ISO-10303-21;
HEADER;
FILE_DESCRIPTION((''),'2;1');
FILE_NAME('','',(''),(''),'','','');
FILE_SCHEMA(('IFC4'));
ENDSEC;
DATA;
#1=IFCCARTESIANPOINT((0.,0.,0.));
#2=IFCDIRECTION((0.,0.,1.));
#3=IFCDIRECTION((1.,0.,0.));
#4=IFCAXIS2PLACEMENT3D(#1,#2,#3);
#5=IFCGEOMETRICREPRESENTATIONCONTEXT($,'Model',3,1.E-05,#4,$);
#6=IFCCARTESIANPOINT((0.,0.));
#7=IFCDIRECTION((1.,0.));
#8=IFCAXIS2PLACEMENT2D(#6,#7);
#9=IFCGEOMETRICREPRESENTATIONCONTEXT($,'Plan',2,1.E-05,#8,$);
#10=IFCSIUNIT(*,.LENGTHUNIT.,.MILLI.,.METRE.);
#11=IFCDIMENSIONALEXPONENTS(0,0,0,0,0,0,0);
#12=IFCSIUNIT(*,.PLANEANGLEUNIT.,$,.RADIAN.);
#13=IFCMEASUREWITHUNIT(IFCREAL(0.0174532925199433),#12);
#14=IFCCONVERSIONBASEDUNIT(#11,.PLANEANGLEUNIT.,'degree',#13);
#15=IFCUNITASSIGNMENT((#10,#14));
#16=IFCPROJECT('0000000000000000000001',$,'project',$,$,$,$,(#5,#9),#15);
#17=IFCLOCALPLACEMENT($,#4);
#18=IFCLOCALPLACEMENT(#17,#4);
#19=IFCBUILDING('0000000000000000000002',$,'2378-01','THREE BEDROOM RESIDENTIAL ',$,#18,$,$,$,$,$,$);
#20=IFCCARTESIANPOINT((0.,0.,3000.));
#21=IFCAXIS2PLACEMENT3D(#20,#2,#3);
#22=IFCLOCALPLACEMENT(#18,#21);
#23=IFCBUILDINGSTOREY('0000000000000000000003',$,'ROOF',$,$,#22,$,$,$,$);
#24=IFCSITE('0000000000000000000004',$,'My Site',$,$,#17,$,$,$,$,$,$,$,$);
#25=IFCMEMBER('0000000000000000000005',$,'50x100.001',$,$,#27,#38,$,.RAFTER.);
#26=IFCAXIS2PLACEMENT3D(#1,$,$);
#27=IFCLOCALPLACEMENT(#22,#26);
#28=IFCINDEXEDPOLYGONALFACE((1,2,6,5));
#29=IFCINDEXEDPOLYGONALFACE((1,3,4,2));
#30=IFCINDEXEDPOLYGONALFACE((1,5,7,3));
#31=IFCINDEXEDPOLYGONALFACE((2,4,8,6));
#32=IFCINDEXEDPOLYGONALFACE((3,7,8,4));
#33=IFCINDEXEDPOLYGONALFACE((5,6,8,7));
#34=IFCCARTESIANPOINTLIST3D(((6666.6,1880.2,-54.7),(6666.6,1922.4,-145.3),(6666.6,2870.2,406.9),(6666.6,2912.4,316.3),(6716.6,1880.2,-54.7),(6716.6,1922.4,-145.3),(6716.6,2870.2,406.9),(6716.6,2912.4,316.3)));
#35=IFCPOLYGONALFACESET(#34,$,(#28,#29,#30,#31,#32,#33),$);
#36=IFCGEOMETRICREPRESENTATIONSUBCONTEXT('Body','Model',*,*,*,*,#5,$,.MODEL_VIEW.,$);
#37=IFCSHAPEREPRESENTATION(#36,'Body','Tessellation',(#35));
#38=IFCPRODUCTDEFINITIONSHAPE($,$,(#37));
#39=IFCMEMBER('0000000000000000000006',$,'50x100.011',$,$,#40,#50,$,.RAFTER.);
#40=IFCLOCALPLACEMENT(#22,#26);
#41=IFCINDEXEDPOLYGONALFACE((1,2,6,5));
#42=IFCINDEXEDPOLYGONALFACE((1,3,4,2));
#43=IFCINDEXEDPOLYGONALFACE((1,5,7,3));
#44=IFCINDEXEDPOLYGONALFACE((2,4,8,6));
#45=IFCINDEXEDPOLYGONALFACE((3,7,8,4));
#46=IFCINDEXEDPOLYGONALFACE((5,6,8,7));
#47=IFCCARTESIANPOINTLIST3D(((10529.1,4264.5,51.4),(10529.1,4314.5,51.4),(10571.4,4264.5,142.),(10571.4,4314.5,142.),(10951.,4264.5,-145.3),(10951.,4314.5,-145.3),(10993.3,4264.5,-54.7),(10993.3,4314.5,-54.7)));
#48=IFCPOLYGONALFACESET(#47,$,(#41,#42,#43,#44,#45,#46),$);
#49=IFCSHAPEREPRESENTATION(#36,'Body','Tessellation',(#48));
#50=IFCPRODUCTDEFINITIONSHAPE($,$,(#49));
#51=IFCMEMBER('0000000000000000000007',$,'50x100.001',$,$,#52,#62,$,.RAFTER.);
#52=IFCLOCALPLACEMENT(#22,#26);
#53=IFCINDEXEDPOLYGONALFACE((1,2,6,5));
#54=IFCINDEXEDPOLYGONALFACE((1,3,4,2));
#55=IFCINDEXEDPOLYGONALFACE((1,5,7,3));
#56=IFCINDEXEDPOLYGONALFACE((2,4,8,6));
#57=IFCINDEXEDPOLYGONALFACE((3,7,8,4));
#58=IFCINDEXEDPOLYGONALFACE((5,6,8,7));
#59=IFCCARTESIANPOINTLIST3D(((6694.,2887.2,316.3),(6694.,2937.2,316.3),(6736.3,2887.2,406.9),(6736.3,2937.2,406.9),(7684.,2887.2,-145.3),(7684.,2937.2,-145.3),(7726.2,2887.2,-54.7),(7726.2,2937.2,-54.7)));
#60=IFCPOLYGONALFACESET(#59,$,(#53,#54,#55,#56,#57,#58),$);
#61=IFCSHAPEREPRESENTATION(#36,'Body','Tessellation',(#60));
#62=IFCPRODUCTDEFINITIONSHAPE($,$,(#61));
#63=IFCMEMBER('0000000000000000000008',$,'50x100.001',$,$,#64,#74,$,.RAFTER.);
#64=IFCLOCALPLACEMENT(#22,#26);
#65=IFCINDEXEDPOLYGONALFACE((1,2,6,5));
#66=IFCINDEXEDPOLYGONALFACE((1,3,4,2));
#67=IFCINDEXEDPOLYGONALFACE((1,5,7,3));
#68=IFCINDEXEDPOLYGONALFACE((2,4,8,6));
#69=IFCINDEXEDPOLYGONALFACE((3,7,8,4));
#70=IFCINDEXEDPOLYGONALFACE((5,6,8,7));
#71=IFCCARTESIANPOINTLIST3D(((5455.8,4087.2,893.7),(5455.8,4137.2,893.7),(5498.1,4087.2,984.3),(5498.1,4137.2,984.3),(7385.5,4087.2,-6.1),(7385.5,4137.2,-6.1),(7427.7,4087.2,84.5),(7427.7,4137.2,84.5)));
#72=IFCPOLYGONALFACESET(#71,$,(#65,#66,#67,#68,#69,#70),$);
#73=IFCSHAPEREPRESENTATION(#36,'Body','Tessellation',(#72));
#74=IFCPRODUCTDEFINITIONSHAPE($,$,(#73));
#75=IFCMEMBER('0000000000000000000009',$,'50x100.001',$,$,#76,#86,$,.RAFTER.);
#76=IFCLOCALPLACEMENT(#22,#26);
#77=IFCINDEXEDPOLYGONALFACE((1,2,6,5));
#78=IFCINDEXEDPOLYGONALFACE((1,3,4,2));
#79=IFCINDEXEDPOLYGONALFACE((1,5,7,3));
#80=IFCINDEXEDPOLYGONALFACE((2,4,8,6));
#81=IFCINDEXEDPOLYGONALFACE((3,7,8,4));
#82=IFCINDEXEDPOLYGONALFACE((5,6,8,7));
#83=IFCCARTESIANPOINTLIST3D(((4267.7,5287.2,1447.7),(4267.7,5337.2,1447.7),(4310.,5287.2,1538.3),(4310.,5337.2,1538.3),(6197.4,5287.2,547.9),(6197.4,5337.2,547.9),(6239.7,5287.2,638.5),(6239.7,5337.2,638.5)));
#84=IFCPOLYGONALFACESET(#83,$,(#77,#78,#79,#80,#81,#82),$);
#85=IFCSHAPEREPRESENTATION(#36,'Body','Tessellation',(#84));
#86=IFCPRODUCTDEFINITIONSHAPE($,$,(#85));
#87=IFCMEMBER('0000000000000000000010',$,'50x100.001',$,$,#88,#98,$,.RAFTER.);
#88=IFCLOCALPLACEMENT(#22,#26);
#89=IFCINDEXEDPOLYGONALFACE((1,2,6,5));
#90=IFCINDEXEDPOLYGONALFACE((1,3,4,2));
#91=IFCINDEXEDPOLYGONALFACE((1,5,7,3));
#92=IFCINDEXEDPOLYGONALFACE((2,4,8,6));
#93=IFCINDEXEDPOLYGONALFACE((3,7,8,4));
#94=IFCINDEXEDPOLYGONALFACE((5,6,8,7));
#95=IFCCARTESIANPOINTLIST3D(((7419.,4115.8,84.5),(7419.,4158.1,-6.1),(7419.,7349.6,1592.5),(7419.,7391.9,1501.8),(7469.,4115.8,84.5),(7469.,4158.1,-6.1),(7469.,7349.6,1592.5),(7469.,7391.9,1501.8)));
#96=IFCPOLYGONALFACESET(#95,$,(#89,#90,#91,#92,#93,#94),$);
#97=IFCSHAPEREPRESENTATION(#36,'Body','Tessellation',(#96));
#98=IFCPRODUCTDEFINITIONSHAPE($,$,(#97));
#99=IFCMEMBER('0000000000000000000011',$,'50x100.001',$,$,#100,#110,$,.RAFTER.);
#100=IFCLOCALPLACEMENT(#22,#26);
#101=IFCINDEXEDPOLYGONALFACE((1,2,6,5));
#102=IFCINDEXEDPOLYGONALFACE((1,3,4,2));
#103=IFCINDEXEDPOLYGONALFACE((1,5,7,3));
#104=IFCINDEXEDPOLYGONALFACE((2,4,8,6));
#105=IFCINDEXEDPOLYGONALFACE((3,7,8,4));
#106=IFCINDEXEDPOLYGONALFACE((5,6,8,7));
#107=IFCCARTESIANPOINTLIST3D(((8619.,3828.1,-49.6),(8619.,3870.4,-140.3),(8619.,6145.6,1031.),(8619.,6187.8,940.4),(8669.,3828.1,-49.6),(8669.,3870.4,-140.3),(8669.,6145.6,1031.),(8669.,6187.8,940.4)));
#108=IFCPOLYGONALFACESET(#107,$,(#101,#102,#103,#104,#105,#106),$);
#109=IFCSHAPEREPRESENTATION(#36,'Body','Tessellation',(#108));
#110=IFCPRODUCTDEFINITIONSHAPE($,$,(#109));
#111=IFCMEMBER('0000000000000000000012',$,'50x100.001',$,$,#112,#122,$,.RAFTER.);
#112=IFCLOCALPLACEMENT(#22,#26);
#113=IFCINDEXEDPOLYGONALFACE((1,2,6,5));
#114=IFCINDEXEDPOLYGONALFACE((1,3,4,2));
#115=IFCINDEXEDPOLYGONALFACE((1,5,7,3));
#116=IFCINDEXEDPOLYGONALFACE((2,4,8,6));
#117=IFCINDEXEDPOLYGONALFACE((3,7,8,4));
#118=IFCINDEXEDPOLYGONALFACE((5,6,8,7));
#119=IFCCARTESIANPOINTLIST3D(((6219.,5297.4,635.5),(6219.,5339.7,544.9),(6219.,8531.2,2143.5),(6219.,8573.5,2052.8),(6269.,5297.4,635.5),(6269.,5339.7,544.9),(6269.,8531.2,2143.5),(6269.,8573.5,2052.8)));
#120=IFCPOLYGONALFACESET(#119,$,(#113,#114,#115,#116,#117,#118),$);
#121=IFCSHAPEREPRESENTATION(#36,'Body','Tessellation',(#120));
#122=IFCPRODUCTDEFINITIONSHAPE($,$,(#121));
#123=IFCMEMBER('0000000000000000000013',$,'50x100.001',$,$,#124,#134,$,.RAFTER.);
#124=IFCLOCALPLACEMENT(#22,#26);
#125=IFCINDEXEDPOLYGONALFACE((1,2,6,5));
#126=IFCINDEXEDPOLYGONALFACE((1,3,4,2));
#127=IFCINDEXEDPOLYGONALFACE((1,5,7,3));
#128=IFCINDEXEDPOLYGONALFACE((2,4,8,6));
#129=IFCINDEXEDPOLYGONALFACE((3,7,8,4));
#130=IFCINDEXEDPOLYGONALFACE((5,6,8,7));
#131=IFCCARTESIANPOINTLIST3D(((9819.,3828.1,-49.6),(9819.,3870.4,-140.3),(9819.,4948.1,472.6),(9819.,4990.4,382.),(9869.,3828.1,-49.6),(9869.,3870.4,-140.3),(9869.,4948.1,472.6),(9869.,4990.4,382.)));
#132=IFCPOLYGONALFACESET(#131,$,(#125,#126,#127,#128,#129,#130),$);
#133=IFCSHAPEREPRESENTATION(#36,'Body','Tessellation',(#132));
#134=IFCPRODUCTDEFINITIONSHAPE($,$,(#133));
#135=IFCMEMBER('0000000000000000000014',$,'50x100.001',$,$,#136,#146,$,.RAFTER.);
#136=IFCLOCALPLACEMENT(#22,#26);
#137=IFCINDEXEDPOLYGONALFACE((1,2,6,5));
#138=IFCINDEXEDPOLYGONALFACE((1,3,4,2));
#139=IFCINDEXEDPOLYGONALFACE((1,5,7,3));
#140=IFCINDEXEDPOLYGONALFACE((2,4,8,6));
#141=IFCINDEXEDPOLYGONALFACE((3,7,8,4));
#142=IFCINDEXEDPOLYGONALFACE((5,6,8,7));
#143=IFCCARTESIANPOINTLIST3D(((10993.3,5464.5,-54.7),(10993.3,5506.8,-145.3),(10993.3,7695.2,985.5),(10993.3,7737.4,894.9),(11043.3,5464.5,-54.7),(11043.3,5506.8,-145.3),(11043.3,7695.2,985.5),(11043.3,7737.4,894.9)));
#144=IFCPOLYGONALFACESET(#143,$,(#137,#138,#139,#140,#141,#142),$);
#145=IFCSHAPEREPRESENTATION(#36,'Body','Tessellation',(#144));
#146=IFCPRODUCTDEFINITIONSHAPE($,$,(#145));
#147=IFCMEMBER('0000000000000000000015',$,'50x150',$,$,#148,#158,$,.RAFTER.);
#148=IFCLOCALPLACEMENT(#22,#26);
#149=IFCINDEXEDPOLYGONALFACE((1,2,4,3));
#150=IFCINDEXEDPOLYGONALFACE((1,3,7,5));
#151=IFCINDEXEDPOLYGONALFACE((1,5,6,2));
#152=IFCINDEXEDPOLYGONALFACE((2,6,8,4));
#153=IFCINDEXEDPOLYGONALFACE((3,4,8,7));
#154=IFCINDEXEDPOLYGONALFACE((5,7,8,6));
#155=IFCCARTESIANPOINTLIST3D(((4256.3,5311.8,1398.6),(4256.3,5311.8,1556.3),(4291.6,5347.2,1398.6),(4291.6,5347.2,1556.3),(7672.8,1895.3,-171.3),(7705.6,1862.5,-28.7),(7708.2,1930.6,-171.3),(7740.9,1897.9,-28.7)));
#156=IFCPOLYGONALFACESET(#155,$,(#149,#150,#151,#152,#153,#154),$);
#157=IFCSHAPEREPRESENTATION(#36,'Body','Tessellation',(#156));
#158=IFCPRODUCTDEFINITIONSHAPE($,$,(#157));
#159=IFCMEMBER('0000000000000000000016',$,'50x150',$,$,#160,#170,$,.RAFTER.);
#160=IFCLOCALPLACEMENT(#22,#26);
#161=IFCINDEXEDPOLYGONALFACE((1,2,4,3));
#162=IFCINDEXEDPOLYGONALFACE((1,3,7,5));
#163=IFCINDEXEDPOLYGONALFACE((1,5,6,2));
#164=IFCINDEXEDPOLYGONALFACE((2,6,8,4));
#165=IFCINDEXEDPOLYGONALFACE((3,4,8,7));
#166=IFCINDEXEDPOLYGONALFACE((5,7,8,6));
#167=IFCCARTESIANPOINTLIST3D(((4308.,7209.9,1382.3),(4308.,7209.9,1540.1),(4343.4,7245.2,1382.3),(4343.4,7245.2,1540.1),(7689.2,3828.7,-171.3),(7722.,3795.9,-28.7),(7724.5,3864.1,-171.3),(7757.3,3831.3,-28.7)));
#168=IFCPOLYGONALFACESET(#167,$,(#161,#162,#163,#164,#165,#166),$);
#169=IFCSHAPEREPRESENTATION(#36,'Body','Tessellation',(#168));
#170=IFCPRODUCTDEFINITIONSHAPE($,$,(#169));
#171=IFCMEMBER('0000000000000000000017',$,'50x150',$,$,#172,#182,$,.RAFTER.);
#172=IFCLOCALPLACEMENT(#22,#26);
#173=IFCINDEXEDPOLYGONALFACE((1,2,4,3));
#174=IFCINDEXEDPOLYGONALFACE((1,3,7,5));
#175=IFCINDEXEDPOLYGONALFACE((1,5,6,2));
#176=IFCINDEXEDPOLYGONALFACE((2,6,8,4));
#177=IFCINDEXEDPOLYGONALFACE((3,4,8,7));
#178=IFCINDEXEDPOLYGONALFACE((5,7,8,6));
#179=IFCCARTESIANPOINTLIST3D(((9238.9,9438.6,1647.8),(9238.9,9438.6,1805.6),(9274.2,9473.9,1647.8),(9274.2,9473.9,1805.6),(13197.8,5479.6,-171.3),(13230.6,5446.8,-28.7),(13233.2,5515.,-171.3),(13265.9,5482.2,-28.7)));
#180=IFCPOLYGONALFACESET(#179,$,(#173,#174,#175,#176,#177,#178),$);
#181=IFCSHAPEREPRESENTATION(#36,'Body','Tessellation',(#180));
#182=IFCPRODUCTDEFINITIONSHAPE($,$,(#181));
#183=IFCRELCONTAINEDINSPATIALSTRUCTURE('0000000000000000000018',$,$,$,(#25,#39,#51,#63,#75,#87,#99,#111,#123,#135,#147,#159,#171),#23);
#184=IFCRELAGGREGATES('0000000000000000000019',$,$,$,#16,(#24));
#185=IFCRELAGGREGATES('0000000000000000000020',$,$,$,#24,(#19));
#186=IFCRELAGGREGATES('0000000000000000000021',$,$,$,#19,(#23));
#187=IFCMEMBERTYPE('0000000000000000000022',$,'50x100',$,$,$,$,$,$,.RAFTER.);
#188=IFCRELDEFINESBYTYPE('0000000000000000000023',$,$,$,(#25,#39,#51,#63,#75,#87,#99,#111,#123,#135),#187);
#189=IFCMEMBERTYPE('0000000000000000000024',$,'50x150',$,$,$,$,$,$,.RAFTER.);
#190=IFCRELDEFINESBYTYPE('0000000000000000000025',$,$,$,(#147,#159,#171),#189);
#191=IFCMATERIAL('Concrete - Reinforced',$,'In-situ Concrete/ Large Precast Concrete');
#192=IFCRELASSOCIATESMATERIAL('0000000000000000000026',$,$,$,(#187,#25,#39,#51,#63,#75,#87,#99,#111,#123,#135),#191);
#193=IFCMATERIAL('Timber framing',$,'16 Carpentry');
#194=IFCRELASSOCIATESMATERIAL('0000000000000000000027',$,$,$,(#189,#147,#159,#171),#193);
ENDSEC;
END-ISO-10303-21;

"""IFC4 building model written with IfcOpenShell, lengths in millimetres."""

from ifc_helpers import new_model, entity, si_unit, converted_unit, frame, origin_with_axes, origin_2d_with_axis, place, context, subcontext, project, spatial, rectangle, extrude, clip, halfspace, material, material_profile, profile_set, profile_usage, type_object, element, save


model = new_model("IFC4")

# Units and contexts
model_context = context("Model", 3, precision=1e-05, world=origin_with_axes())
plan_context = context("Plan", 2, precision=1e-05, world=origin_2d_with_axis())
body_context = subcontext(model_context, "Body", "Model", "MODEL_VIEW")
ifc_project = project(units=[si_unit("LENGTHUNIT", "METRE", prefix="MILLI"), converted_unit("PLANEANGLEUNIT", "degree", entity("IfcReal", 0.0174532925199433), si_unit("PLANEANGLEUNIT", "RADIAN"), dimensions=[0, 0, 0, 0, 0, 0, 0])], contexts=[model_context, plan_context])

# Site, building, storey
site_placement = place(None, origin_with_axes())
site = spatial("IfcSite", under=ifc_project, at=site_placement, Name="My Site")
building_placement = place(site_placement, origin_with_axes())
building = spatial("IfcBuilding", under=site, at=building_placement, Name="2378-01", Description="THREE BEDROOM RESIDENTIAL ")
storey_placement = place(building_placement, frame((0.0, 0.0, 3000.0), z_axis=(0.0, 0.0, 1.0), x_axis=(1.0, 0.0, 0.0)))
storey = spatial("IfcBuildingStorey", under=building, at=storey_placement, Name="ROOF")

# Members
ifc_material_1 = material(Name="Concrete - Reinforced", Category="In-situ Concrete/ Large Precast Concrete")
ifc_material_profile_1 = material_profile(ifc_material_1, rectangle(XDim=50.0, YDim=100.0), Name="Core Layer", Category="LoadBearing", Priority=1)
ifc_profile_set_1 = profile_set([ifc_material_profile_1], Name="wood")
ifc_profile_usage_1 = profile_usage(ifc_profile_set_1)
member_type_1 = type_object("IfcMemberType", Name="50x100", PredefinedType="RAFTER", material=ifc_profile_set_1)
member_1_placement = place(storey_placement, frame((6691.6, 1901.3, -100.0), z_axis=(0.0, 0.906308, 0.422618), x_axis=(-1.0, 0.0, 0.0)))
element("IfcMember", 1, at=member_1_placement, inside=storey, type_object=member_type_1, material=ifc_profile_usage_1, Name="50x100.001", PredefinedType="RAFTER", context=body_context, shape_type="SweptSolid", body=[
    extrude(rectangle(XDim=50.0, YDim=100.0), origin_with_axes(), (0.0, 0.0, 1.0), 1092.3),
])
ifc_profile_usage_2 = profile_usage(ifc_profile_set_1, cardinal=5)
member_2_placement = place(storey_placement, frame((10972.1, 4289.5, -100.0), z_axis=(-0.906308, 0.0, 0.422618), x_axis=(0.0, -1.0, 0.0)))
element("IfcMember", 2, at=member_2_placement, inside=storey, type_object=member_type_1, material=ifc_profile_usage_2, Name="50x100.011", PredefinedType="RAFTER", context=body_context, shape_type="SweptSolid", body=[
    extrude(rectangle(XDim=50.0, YDim=100.0), origin_with_axes(), (0.0, 0.0, 1.0), 465.5),
])
ifc_profile_usage_3 = profile_usage(ifc_profile_set_1)
member_3_placement = place(storey_placement, frame((7705.1, 2912.2, -100.0), z_axis=(-0.906308, 0.0, 0.422618), x_axis=(0.0, -1.0, 0.0)))
element("IfcMember", 3, at=member_3_placement, inside=storey, type_object=member_type_1, material=ifc_profile_usage_3, Name="50x100.001", PredefinedType="RAFTER", context=body_context, shape_type="SweptSolid", body=[
    extrude(rectangle(XDim=50.0, YDim=100.0), origin_with_axes(), (0.0, 0.0, 1.0), 1092.3),
])
ifc_profile_usage_4 = profile_usage(ifc_profile_set_1)
member_4_placement = place(storey_placement, frame((7406.6, 4112.2, 39.2), z_axis=(-0.906308, 0.0, 0.422618), x_axis=(0.0, -1.0, 0.0)))
element("IfcMember", 4, at=member_4_placement, inside=storey, type_object=member_type_1, material=ifc_profile_usage_4, Name="50x100.001", PredefinedType="RAFTER", context=body_context, shape_type="SweptSolid", body=[
    extrude(rectangle(XDim=50.0, YDim=100.0), origin_with_axes(), (0.0, 0.0, 1.0), 2129.1),
])
ifc_profile_usage_5 = profile_usage(ifc_profile_set_1)
member_5_placement = place(storey_placement, frame((6218.5, 5312.2, 593.2), z_axis=(-0.906308, 0.0, 0.422618), x_axis=(0.0, -1.0, 0.0)))
element("IfcMember", 5, at=member_5_placement, inside=storey, type_object=member_type_1, material=ifc_profile_usage_5, Name="50x100.001", PredefinedType="RAFTER", context=body_context, shape_type="SweptSolid", body=[
    extrude(rectangle(XDim=50.0, YDim=100.0), origin_with_axes(), (0.0, 0.0, 1.0), 2129.1),
])
ifc_profile_usage_6 = profile_usage(ifc_profile_set_1)
member_6_placement = place(storey_placement, frame((7444.0, 4136.9, 39.2), z_axis=(0.0, 0.906308, 0.422618), x_axis=(-1.0, 0.0, 0.0)))
element("IfcMember", 6, at=member_6_placement, inside=storey, type_object=member_type_1, material=ifc_profile_usage_6, Name="50x100.001", PredefinedType="RAFTER", context=body_context, shape_type="SweptSolid", body=[
    extrude(rectangle(XDim=50.0, YDim=100.0), origin_with_axes(), (0.0, 0.0, 1.0), 3568.1),
])
ifc_profile_usage_7 = profile_usage(ifc_profile_set_1)
member_7_placement = place(storey_placement, frame((8644.0, 3849.3, -94.9), z_axis=(0.0, 0.906308, 0.422618), x_axis=(-1.0, 0.0, 0.0)))
element("IfcMember", 7, at=member_7_placement, inside=storey, type_object=member_type_1, material=ifc_profile_usage_7, Name="50x100.001", PredefinedType="RAFTER", context=body_context, shape_type="SweptSolid", body=[
    extrude(rectangle(XDim=50.0, YDim=100.0), origin_with_axes(), (0.0, 0.0, 1.0), 2557.0),
])
ifc_profile_usage_8 = profile_usage(ifc_profile_set_1)
member_8_placement = place(storey_placement, frame((6244.0, 5318.5, 590.2), z_axis=(0.0, 0.906308, 0.422618), x_axis=(-1.0, 0.0, 0.0)))
element("IfcMember", 8, at=member_8_placement, inside=storey, type_object=member_type_1, material=ifc_profile_usage_8, Name="50x100.001", PredefinedType="RAFTER", context=body_context, shape_type="SweptSolid", body=[
    extrude(rectangle(XDim=50.0, YDim=100.0), origin_with_axes(), (0.0, 0.0, 1.0), 3568.1),
])
ifc_profile_usage_9 = profile_usage(ifc_profile_set_1)
member_9_placement = place(storey_placement, frame((9844.0, 3849.3, -94.9), z_axis=(0.0, 0.906308, 0.422618), x_axis=(-1.0, 0.0, 0.0)))
element("IfcMember", 9, at=member_9_placement, inside=storey, type_object=member_type_1, material=ifc_profile_usage_9, Name="50x100.001", PredefinedType="RAFTER", context=body_context, shape_type="SweptSolid", body=[
    extrude(rectangle(XDim=50.0, YDim=100.0), origin_with_axes(), (0.0, 0.0, 1.0), 1235.7),
])
ifc_profile_usage_10 = profile_usage(ifc_profile_set_1)
member_10_placement = place(storey_placement, frame((11018.3, 5485.6, -100.0), z_axis=(0.0, 0.906308, 0.422618), x_axis=(-1.0, 0.0, 0.0)))
element("IfcMember", 10, at=member_10_placement, inside=storey, type_object=member_type_1, material=ifc_profile_usage_10, Name="50x100.001", PredefinedType="RAFTER", context=body_context, shape_type="SweptSolid", body=[
    extrude(rectangle(XDim=50.0, YDim=100.0), origin_with_axes(), (0.0, 0.0, 1.0), 2461.3),
])
ifc_material_2 = material(Name="Timber framing", Category="16 Carpentry")
ifc_material_profile_2 = material_profile(ifc_material_2, rectangle(XDim=50.0, YDim=150.0), Name="Lumber", Category="LoadBearing", Priority=1)
ifc_profile_set_2 = profile_set([ifc_material_profile_2], Name="wood")
ifc_profile_usage_11 = profile_usage(ifc_profile_set_2)
member_type_2 = type_object("IfcMemberType", Name="50x150", PredefinedType="RAFTER", material=ifc_profile_set_2)
member_11_placement = place(storey_placement, frame((7706.9, 1896.6, -100.0), z_axis=(-0.672498, 0.672499, 0.309017), x_axis=(-0.707107, -0.707107, 0.0)))
element("IfcMember", 11, at=member_11_placement, inside=storey, type_object=member_type_2, material=ifc_profile_usage_11, Name="50x150", PredefinedType="RAFTER", context=body_context, shape_type="Clipping", body=[
    clip(extrude(rectangle(XDim=50.0, YDim=150.0), origin_with_axes(), (0.0, 0.0, 1.0), 5254.7), halfspace(frame((4829.9, -1500.2, 4617.3), z_axis=(0.0, -0.309017, 0.951056), x_axis=(-1.0, 0.000001, 0.0)), False)),
])
ifc_profile_usage_12 = profile_usage(ifc_profile_set_2)
member_12_placement = place(storey_placement, frame((7723.3, 3830.0, -100.0), z_axis=(-0.672498, 0.672499, 0.309017), x_axis=(-0.707107, -0.707107, 0.0)))
element("IfcMember", 12, at=member_12_placement, inside=storey, type_object=member_type_2, material=ifc_profile_usage_12, Name="50x150", PredefinedType="RAFTER", context=body_context, shape_type="Clipping", body=[
    clip(extrude(rectangle(XDim=50.0, YDim=150.0), origin_with_axes(), (0.0, 0.0, 1.0), 5202.2), halfspace(frame((4829.9, -1294.6, 4631.5), z_axis=(0.0, -0.309017, 0.951056), x_axis=(-1.0, 0.000001, 0.0)), False)),
])
ifc_profile_usage_13 = profile_usage(ifc_profile_set_2)
member_13_placement = place(storey_placement, frame((13231.9, 5480.9, -100.0), z_axis=(-0.672498, 0.672499, 0.309017), x_axis=(-0.707107, -0.707107, 0.0)))
element("IfcMember", 13, at=member_13_placement, inside=storey, type_object=member_type_2, material=ifc_profile_usage_13, Name="50x150", PredefinedType="RAFTER", context=body_context, shape_type="Clipping", body=[
    clip(extrude(rectangle(XDim=50.0, YDim=150.0), origin_with_axes(), (0.0, 0.0, 1.0), 6061.3), halfspace(frame((-1891.5, -293.3, 5816.0), z_axis=(0.0, -0.309017, 0.951056), x_axis=(-1.0, -0.000001, 0.0)), False)),
])

save(model, "model.ifc")
